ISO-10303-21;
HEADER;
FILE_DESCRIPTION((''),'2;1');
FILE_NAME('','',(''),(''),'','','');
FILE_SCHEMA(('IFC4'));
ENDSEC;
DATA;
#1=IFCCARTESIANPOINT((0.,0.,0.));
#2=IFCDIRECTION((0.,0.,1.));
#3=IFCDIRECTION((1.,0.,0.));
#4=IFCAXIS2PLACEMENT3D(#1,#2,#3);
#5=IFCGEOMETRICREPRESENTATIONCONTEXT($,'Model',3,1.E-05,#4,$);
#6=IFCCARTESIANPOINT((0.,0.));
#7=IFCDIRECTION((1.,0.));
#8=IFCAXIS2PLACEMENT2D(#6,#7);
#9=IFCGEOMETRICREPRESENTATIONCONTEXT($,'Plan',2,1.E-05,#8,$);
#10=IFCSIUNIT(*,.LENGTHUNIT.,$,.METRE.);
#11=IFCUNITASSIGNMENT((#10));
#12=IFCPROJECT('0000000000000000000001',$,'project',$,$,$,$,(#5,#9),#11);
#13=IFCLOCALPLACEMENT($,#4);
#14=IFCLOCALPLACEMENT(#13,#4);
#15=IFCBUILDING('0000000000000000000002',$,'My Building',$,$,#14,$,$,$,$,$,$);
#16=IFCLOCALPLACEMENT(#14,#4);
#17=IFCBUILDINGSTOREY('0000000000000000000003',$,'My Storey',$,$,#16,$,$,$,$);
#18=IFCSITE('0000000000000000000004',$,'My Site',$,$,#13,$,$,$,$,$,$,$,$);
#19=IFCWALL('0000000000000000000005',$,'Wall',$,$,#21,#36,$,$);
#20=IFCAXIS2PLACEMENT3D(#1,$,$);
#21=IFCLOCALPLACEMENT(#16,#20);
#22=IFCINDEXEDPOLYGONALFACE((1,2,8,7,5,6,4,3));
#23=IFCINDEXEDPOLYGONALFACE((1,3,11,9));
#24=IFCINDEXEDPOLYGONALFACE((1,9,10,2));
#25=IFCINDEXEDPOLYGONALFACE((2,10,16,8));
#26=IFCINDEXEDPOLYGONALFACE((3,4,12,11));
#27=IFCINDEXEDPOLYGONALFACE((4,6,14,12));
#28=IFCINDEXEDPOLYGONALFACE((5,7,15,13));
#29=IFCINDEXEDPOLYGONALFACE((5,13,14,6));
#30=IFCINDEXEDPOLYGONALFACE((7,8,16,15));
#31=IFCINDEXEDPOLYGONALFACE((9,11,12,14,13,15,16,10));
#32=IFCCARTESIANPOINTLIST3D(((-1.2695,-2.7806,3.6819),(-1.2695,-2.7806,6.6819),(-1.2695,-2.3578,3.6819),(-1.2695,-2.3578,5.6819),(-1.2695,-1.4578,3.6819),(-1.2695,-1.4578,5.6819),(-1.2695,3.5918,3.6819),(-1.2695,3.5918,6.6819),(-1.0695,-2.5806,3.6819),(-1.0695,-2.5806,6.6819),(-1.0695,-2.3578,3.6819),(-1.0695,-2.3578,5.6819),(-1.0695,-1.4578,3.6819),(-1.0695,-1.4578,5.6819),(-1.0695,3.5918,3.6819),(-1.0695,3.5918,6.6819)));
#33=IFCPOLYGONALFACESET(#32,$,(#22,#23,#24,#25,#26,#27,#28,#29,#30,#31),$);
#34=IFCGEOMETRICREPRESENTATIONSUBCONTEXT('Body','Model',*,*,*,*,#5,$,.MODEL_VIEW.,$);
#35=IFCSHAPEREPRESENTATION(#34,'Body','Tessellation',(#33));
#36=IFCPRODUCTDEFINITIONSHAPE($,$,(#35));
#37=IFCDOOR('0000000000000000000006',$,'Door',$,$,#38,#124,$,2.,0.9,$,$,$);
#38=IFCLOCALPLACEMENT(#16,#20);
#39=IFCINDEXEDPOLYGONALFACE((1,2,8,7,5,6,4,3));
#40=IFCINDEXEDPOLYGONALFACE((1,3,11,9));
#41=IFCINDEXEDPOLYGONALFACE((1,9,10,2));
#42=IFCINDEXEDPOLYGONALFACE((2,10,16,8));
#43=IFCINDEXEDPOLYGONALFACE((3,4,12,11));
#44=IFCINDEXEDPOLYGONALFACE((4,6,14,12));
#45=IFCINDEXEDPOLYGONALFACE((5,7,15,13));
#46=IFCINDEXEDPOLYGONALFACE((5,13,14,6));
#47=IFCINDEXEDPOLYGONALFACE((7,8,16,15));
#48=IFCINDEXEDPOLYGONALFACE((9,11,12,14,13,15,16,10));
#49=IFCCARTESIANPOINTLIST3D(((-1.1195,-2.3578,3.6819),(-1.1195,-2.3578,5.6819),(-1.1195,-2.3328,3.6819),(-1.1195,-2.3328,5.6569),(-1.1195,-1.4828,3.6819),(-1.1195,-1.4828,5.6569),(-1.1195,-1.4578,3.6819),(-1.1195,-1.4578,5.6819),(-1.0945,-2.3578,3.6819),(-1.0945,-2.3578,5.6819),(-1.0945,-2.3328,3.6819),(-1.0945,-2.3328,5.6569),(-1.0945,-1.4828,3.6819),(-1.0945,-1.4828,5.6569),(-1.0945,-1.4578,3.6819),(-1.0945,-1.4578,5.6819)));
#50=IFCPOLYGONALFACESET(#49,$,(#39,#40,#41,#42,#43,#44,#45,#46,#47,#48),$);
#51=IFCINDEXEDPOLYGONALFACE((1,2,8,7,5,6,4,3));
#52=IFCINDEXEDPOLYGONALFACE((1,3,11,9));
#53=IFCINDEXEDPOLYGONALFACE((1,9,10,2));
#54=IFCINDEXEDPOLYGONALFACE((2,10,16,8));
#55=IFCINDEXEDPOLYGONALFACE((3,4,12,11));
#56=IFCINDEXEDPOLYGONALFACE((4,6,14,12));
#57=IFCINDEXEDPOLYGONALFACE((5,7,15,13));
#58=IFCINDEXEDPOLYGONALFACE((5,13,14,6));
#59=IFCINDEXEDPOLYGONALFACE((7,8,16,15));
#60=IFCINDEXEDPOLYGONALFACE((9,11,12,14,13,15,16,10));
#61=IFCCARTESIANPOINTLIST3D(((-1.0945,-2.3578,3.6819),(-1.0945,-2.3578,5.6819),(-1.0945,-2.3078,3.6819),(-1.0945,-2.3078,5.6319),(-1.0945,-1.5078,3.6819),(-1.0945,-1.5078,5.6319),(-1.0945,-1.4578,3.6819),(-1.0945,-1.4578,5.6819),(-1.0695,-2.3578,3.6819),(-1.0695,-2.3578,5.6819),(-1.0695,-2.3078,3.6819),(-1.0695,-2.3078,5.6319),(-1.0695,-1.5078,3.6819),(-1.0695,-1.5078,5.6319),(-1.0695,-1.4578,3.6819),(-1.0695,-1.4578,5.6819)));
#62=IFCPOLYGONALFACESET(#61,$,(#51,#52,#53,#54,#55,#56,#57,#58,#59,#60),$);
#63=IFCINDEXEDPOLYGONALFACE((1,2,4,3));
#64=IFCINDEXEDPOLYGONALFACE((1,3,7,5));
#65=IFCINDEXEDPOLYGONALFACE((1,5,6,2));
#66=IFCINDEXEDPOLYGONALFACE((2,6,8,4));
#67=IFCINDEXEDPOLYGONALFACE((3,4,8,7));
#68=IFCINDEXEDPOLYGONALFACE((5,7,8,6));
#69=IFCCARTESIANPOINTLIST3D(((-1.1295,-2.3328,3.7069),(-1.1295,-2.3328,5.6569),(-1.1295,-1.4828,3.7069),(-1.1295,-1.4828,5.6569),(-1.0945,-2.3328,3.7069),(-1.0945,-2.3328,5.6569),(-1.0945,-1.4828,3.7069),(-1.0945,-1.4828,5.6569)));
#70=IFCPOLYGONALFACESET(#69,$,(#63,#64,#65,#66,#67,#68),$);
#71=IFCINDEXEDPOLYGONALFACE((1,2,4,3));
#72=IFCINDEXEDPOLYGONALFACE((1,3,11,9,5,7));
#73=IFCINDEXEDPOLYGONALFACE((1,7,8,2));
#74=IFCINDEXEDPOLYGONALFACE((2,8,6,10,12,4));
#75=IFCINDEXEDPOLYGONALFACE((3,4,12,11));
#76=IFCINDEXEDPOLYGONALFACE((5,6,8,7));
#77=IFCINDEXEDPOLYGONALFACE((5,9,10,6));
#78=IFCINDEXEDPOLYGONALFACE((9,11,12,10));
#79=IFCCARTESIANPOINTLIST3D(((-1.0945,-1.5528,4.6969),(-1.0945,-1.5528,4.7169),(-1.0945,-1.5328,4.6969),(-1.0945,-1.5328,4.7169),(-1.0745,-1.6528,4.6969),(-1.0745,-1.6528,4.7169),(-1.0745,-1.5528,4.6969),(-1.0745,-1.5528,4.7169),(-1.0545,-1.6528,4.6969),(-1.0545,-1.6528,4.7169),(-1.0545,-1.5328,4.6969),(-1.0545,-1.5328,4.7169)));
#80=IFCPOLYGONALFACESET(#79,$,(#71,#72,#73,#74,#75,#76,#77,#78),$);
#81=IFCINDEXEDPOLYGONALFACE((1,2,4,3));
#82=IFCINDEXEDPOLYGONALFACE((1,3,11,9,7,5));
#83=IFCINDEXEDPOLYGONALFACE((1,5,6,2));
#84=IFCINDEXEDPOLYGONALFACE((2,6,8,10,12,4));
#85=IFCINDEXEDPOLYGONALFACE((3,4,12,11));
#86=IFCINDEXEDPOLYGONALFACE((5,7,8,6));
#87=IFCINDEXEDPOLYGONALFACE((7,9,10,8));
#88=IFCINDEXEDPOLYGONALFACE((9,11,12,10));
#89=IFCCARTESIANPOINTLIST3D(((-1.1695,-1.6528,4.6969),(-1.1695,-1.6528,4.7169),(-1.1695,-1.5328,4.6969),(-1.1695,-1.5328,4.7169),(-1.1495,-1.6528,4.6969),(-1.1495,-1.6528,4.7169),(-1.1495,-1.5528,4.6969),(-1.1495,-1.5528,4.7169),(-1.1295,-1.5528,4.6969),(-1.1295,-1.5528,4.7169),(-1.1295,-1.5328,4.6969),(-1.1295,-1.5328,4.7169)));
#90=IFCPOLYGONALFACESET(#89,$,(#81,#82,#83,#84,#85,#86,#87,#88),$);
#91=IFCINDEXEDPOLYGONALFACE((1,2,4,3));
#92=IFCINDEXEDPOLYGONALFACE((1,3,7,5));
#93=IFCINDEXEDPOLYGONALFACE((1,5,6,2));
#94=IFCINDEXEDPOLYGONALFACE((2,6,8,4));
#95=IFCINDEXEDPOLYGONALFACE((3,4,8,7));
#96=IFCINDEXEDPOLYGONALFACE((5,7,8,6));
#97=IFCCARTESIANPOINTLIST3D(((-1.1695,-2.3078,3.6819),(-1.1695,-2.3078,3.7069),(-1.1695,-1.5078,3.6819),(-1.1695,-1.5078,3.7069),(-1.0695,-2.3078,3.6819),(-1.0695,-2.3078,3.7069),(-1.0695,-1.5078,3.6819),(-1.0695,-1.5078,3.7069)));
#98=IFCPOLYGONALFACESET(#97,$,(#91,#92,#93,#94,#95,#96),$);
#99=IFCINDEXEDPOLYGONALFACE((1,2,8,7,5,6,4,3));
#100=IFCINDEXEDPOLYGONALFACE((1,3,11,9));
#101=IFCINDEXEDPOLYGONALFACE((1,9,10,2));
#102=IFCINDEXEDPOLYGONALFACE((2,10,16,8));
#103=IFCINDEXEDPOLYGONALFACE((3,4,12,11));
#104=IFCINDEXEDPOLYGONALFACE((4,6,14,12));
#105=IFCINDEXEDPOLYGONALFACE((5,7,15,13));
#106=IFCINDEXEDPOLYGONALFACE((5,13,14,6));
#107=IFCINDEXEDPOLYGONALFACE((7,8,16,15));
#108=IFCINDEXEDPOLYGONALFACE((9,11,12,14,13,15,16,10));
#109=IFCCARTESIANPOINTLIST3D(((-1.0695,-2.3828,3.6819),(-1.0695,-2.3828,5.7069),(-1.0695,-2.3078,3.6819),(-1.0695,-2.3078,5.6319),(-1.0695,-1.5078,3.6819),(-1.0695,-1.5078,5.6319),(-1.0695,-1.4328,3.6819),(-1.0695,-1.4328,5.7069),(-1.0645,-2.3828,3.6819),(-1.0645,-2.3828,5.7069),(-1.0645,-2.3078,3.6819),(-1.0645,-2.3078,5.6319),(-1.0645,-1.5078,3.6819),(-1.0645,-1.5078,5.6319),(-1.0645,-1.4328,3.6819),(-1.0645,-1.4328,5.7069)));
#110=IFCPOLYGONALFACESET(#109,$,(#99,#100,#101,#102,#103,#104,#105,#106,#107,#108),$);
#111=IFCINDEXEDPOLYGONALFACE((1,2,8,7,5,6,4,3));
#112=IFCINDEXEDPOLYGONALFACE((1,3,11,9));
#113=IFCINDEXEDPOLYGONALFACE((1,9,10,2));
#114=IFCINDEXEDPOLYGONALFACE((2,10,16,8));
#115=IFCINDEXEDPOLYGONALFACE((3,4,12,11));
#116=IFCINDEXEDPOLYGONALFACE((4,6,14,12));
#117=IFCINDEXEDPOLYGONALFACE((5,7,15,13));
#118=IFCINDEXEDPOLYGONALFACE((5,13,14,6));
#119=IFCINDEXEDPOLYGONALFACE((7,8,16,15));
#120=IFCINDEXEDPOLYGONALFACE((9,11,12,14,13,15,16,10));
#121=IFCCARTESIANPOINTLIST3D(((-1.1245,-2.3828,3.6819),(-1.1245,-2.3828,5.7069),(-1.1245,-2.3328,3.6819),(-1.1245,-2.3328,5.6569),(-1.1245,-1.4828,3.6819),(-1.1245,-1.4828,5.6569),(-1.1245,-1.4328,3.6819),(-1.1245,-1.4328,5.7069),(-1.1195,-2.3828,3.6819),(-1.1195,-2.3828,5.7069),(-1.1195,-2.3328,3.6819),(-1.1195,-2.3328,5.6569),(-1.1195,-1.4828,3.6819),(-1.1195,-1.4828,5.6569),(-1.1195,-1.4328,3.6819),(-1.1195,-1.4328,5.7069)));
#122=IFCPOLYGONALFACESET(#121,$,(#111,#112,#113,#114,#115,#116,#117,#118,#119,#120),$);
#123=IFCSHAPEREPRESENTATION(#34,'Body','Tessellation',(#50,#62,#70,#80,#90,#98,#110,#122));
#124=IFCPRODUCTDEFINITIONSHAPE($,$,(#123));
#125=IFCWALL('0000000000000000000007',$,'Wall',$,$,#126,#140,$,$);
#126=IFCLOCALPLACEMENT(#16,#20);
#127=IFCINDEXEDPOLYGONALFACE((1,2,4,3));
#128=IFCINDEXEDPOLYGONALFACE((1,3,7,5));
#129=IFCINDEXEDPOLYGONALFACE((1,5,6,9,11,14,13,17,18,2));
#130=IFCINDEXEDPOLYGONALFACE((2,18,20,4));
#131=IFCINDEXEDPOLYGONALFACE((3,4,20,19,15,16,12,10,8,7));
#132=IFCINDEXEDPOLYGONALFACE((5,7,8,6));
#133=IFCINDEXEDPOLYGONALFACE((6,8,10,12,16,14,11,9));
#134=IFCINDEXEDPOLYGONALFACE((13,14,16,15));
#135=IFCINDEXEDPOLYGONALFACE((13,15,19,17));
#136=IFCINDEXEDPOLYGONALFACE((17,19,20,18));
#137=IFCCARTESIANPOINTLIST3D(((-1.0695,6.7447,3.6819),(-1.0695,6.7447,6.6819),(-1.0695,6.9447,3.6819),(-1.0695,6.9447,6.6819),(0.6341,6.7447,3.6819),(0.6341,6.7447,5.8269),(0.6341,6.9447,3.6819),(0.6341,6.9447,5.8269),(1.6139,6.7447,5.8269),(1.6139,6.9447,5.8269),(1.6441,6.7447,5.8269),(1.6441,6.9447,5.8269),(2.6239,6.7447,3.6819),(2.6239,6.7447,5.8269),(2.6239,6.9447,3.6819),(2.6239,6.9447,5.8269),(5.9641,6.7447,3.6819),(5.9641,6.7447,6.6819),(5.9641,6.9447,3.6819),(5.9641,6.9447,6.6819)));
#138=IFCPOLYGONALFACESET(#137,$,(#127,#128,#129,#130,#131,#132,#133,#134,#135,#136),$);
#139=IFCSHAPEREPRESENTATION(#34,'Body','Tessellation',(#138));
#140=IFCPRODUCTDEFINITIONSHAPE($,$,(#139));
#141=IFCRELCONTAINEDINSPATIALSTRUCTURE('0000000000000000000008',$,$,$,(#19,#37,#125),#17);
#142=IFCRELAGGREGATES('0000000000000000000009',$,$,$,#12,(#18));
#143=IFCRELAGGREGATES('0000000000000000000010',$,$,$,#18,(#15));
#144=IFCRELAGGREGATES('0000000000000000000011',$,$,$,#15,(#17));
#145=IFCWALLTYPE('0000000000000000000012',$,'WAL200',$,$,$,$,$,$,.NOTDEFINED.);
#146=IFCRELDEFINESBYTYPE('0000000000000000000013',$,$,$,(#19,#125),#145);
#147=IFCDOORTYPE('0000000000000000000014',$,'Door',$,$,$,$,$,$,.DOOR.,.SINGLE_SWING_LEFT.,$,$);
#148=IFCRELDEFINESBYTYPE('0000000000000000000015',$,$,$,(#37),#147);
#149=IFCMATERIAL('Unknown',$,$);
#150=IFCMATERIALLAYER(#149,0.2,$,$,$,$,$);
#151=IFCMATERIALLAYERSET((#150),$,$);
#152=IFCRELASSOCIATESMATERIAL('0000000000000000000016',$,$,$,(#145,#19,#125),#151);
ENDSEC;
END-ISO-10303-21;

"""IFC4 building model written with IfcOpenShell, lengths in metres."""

from ifc_helpers import new_model, entity, si_unit, frame, origin_with_axes, origin_2d_with_axis, place, context, subcontext, project, spatial, line, indexed_curve, outline, extrude, shape, source, transform, mapped, material, layer, layer_set, layer_usage, type_object, type_shapes, element, fill, save


model = new_model("IFC4")

# Units and contexts
model_context = context("Model", 3, precision=1e-05, world=origin_with_axes())
plan_context = context("Plan", 2, precision=1e-05, world=origin_2d_with_axis())
body_context_1 = subcontext(model_context, "Body", "Model", "MODEL_VIEW")
body_context_2 = subcontext(plan_context, "Body", "Plan", "PLAN_VIEW")
ifc_project = project(units=[si_unit("LENGTHUNIT", "METRE")], contexts=[model_context, plan_context])

# Site, building, storey
site_placement = place(None, origin_with_axes())
site = spatial("IfcSite", under=ifc_project, at=site_placement, Name="My Site")
building_placement = place(site_placement, origin_with_axes())
building = spatial("IfcBuilding", under=site, at=building_placement, Name="My Building")
storey_placement = place(building_placement, origin_with_axes())
storey = spatial("IfcBuildingStorey", under=building, at=storey_placement, Name="My Storey")

# Shared definitions
ifc_material = material(Name="Unknown")

# Shared definitions
ifc_layer = layer(ifc_material, 0.2)
ifc_layer_set = layer_set([ifc_layer])
wall_type = type_object("IfcWallType", Name="WAL200", PredefinedType="NOTDEFINED", material=ifc_layer_set)

# Shared definitions
shared_shape_1 = source(origin_with_axes(), body_context_1, "Body", "SweptSolid", [
    extrude(outline(indexed_curve([(0.0, 0.0), (0.9, 0.0), (0.9, 2.0), (0.0, 2.0)], segments=[line(1, 2, 3, 4, 1)])), frame((0.0, -0.6, 0.0), z_axis=(0.0, -1.0, 0.0), x_axis=(1.0, 0.0, 0.0)), (0.0, 0.0, -1.0), 1.2),
])
door_type = type_object("IfcDoorType", Name="Door", OperationType="SINGLE_SWING_LEFT", PredefinedType="DOOR")
shared_shape_2 = source(origin_with_axes(), body_context_1, "Body", "SweptSolid", [
    extrude(outline(indexed_curve([(0.0, 0.0), (0.0, 2.0), (0.9, 2.0), (0.9, 0.0), (0.875, 0.0), (0.875, 1.975), (0.025, 1.975), (0.025, 0.0)], segments=[line(1, 2, 3, 4, 5, 6, 7, 8, 1)])), frame((0.0, 0.025, 0.0), z_axis=(0.0, -1.0, 0.0), x_axis=(1.0, 0.0, 0.0)), (0.0, 0.0, -1.0), 0.025),
    extrude(outline(indexed_curve([(0.0, 0.0), (0.0, 2.0), (0.9, 2.0), (0.9, 0.0), (0.85, 0.0), (0.85, 1.95), (0.05, 1.95), (0.05, 0.0)], segments=[line(1, 2, 3, 4, 5, 6, 7, 8, 1)])), frame((0.0, 0.0, 0.0), z_axis=(0.0, -1.0, 0.0), x_axis=(1.0, 0.0, 0.0)), (0.0, 0.0, -1.0), 0.025),
    extrude(outline(indexed_curve([(0.0, 0.0), (0.85, 0.0), (0.85, 0.035), (0.0, 0.035)], segments=[line(1, 2, 3, 4, 1)])), frame((0.025, 0.025, 0.025), z_axis=(0.0, 0.0, 1.0), x_axis=(1.0, 0.0, 0.0)), (0.0, 0.0, 1.0), 1.95),
    extrude(outline(indexed_curve([(0.0, 0.0), (0.0, -0.04), (-0.12, -0.04), (-0.12, -0.02), (-0.02, -0.02), (-0.02, 0.0)], segments=[line(1, 2, 3, 4, 5, 6, 1)])), frame((0.825, 0.025, 1.015), z_axis=(0.0, 0.0, 1.0), x_axis=(1.0, 0.0, 0.0)), (0.0, 0.0, 1.0), 0.02),
    extrude(outline(indexed_curve([(0.0, 0.0), (0.0, 0.04), (-0.12, 0.04), (-0.12, 0.02), (-0.02, 0.02), (-0.02, 0.0)], segments=[line(1, 2, 3, 4, 5, 6, 1)])), frame((0.825, 0.06, 1.015), z_axis=(0.0, 0.0, 1.0), x_axis=(1.0, 0.0, 0.0)), (0.0, 0.0, 1.0), 0.02),
    extrude(outline(indexed_curve([(0.0, 0.0), (0.8, 0.0), (0.8, 0.1), (0.0, 0.1)], segments=[line(1, 2, 3, 4, 1)])), frame((0.05, 0.0, 0.0), z_axis=(0.0, 0.0, 1.0), x_axis=(1.0, 0.0, 0.0)), (0.0, 0.0, 1.0), 0.025),
    extrude(outline(indexed_curve([(0.0, 0.0), (0.0, 2.025), (0.95, 2.025), (0.95, 0.0), (0.875, 0.0), (0.875, 1.95), (0.075, 1.95), (0.075, 0.0)], segments=[line(1, 2, 3, 4, 5, 6, 7, 8, 1)])), frame((-0.025, -0.005, 0.0), z_axis=(0.0, -1.0, 0.0), x_axis=(1.0, 0.0, 0.0)), (0.0, 0.0, -1.0), 0.005),
    extrude(outline(indexed_curve([(0.0, 0.0), (0.0, 2.025), (0.95, 2.025), (0.95, 0.0), (0.9, 0.0), (0.9, 1.975), (0.05, 1.975), (0.05, 0.0)], segments=[line(1, 2, 3, 4, 5, 6, 7, 8, 1)])), frame((-0.025, 0.05, 0.0), z_axis=(0.0, -1.0, 0.0), x_axis=(1.0, 0.0, 0.0)), (0.0, 0.0, -1.0), 0.005),
])
shared_shape_3 = source(origin_with_axes(), body_context_2, "Body", "Curve2D", [
    entity("IfcIndexedPolyCurve", entity("IfcCartesianPointList2D", [[0.0, 0.0], [0.0, 0.05], [0.025, 0.05], [0.025, 0.025], [0.05, 0.025], [0.05, 0.0]]), [entity("IfcLineIndex", [1, 2, 3, 4, 5, 6, 1])]),
    entity("IfcIndexedPolyCurve", entity("IfcCartesianPointList2D", [[0.9, 0.0], [0.9, 0.05], [0.875, 0.05], [0.875, 0.025], [0.85, 0.025], [0.85, 0.0]]), [entity("IfcLineIndex", [1, 2, 3, 4, 5, 6, 1])]),
    entity("IfcTrimmedCurve", entity("IfcEllipse", entity("IfcAxis2Placement2D", entity("IfcCartesianPoint", [0.06, 0.05]), entity("IfcDirection", [1.0, 0.0])), 0.815, 0.85), [entity("IfcCartesianPoint", [0.875, 0.05])], [entity("IfcCartesianPoint", [0.06, 0.9])], True, "CARTESIAN"),
    entity("IfcIndexedPolyCurve", entity("IfcCartesianPointList2D", [[0.025, 0.05], [0.06, 0.05], [0.06, 0.9], [0.025, 0.9]]), [entity("IfcLineIndex", [1, 2, 3, 4, 1])]),
])
type_shapes(door_type, [shared_shape_2, shared_shape_3])

# Wall, opening, door
ifc_layer_usage_1 = layer_usage(ifc_layer_set, "AXIS2", "POSITIVE", 0.0)
wall_1_placement = place(storey_placement, frame((-1.2695, 3.5918, 3.6819), z_axis=(0.0, 0.0, 1.0), x_axis=(0.0, -1.0, 0.0)))
wall_1 = element("IfcWall", 1, at=wall_1_placement, inside=storey, type_object=wall_type, material=ifc_layer_usage_1, Name="Wall", context=body_context_1, shape_type="SweptSolid", body=[
    extrude(outline(indexed_curve([(0.0, 0.0), (0.0, 0.2), (6.1724, 0.2), (6.3724, 0.0)], segments=[line(1, 2, 3, 4, 1)])), origin_with_axes(), (0.0, 0.0, 1.0), 3.0),
])
opening_1_placement = place(wall_1_placement, frame((5.9496, 0.2, 0.0), z_axis=(0.0, 0.0, 1.0), x_axis=(-1.0, 0.0, 0.0)))
opening_1 = element("IfcOpeningElement", 2, at=opening_1_placement, cuts=wall_1, PredefinedType="OPENING", context=body_context_1, shape_type="MappedRepresentation", body=[
    mapped(shared_shape_1, transform((0.0, 0.0, 0.0), x_axis=(1.0, 0.0, 0.0), y_axis=(0.0, 1.0, 0.0), z_axis=(0.0, 0.0, 1.0), scale=1.0)),
])
door_1_placement = place(opening_1_placement, frame((0.0, 0.0, 0.0), z_axis=(0.0, 0.0, 1.0), x_axis=(1.0, 0.0, 0.0)))
door_1 = element("IfcDoor", 3, at=door_1_placement, inside=storey, type_object=door_type, Name="Door", OverallHeight=2.0, OverallWidth=0.9, shapes=[
    shape(body_context_1, "Body", "MappedRepresentation", [mapped(shared_shape_2, transform((0.0, 0.0, 0.0), x_axis=(1.0, 0.0, 0.0), y_axis=(0.0, 1.0, 0.0), z_axis=(0.0, 0.0, 1.0), scale=1.0))]),
    shape(body_context_2, "Body", "MappedRepresentation", [mapped(shared_shape_3, transform((0.0, 0.0, 0.0), x_axis=(1.0, 0.0, 0.0), y_axis=(0.0, 1.0, 0.0), z_axis=(0.0, 0.0, 1.0), scale=1.0))]),
])
fill(opening_1, door_1)

# Wall, openings
ifc_layer_usage_2 = layer_usage(ifc_layer_set, "AXIS2", "POSITIVE", 0.0)
wall_2_placement = place(storey_placement, frame((-1.0695, 6.7447, 3.6819), z_axis=(0.0, 0.0, 1.0), x_axis=(1.0, 0.0, 0.0)))
wall_2 = element("IfcWall", 4, at=wall_2_placement, inside=storey, type_object=wall_type, material=ifc_layer_usage_2, Name="Wall", context=body_context_1, shape_type="SweptSolid", body=[
    extrude(outline(indexed_curve([(0.0, 0.0), (0.0, 0.2), (7.0335, 0.2), (7.0335, 0.0)], segments=[line(1, 2, 3, 4, 1)])), origin_with_axes(), (0.0, 0.0, 1.0), 3.0),
])
shared_shape_4 = source(origin_with_axes(), body_context_1, "Body", "SweptSolid", [
    extrude(outline(indexed_curve([(0.0, 0.0), (1.01, 0.0), (1.01, 2.145), (0.0, 2.145)], segments=[line(1, 2, 3, 4, 1)])), frame((0.0, -0.6, 0.0), z_axis=(0.0, -1.0, 0.0), x_axis=(1.0, 0.0, 0.0)), (0.0, 0.0, -1.0), 1.2),
])
opening_2_placement = place(wall_2_placement, frame((2.7136, 0.2, 0.0), z_axis=(0.0, 0.0, 1.0), x_axis=(-1.0, 0.0, 0.0)))
element("IfcOpeningElement", 5, at=opening_2_placement, cuts=wall_2, PredefinedType="OPENING", context=body_context_1, shape_type="MappedRepresentation", body=[
    mapped(shared_shape_4, transform((0.0, 0.0, 0.0), x_axis=(1.0, 0.0, 0.0), y_axis=(0.0, 1.0, 0.0), z_axis=(0.0, 0.0, 1.0), scale=1.0)),
])
opening_3_placement = place(wall_2_placement, frame((3.6933, 0.2, 0.0), z_axis=(0.0, 0.0, 1.0), x_axis=(-1.0, 0.0, 0.0)))
element("IfcOpeningElement", 6, at=opening_3_placement, cuts=wall_2, PredefinedType="OPENING", context=body_context_1, shape_type="MappedRepresentation", body=[
    mapped(shared_shape_4, transform((0.0, 0.0, 0.0), x_axis=(1.0, 0.0, 0.0), y_axis=(0.0, 1.0, 0.0), z_axis=(0.0, 0.0, 1.0), scale=1.0)),
])

save(model, "model.ifc")
